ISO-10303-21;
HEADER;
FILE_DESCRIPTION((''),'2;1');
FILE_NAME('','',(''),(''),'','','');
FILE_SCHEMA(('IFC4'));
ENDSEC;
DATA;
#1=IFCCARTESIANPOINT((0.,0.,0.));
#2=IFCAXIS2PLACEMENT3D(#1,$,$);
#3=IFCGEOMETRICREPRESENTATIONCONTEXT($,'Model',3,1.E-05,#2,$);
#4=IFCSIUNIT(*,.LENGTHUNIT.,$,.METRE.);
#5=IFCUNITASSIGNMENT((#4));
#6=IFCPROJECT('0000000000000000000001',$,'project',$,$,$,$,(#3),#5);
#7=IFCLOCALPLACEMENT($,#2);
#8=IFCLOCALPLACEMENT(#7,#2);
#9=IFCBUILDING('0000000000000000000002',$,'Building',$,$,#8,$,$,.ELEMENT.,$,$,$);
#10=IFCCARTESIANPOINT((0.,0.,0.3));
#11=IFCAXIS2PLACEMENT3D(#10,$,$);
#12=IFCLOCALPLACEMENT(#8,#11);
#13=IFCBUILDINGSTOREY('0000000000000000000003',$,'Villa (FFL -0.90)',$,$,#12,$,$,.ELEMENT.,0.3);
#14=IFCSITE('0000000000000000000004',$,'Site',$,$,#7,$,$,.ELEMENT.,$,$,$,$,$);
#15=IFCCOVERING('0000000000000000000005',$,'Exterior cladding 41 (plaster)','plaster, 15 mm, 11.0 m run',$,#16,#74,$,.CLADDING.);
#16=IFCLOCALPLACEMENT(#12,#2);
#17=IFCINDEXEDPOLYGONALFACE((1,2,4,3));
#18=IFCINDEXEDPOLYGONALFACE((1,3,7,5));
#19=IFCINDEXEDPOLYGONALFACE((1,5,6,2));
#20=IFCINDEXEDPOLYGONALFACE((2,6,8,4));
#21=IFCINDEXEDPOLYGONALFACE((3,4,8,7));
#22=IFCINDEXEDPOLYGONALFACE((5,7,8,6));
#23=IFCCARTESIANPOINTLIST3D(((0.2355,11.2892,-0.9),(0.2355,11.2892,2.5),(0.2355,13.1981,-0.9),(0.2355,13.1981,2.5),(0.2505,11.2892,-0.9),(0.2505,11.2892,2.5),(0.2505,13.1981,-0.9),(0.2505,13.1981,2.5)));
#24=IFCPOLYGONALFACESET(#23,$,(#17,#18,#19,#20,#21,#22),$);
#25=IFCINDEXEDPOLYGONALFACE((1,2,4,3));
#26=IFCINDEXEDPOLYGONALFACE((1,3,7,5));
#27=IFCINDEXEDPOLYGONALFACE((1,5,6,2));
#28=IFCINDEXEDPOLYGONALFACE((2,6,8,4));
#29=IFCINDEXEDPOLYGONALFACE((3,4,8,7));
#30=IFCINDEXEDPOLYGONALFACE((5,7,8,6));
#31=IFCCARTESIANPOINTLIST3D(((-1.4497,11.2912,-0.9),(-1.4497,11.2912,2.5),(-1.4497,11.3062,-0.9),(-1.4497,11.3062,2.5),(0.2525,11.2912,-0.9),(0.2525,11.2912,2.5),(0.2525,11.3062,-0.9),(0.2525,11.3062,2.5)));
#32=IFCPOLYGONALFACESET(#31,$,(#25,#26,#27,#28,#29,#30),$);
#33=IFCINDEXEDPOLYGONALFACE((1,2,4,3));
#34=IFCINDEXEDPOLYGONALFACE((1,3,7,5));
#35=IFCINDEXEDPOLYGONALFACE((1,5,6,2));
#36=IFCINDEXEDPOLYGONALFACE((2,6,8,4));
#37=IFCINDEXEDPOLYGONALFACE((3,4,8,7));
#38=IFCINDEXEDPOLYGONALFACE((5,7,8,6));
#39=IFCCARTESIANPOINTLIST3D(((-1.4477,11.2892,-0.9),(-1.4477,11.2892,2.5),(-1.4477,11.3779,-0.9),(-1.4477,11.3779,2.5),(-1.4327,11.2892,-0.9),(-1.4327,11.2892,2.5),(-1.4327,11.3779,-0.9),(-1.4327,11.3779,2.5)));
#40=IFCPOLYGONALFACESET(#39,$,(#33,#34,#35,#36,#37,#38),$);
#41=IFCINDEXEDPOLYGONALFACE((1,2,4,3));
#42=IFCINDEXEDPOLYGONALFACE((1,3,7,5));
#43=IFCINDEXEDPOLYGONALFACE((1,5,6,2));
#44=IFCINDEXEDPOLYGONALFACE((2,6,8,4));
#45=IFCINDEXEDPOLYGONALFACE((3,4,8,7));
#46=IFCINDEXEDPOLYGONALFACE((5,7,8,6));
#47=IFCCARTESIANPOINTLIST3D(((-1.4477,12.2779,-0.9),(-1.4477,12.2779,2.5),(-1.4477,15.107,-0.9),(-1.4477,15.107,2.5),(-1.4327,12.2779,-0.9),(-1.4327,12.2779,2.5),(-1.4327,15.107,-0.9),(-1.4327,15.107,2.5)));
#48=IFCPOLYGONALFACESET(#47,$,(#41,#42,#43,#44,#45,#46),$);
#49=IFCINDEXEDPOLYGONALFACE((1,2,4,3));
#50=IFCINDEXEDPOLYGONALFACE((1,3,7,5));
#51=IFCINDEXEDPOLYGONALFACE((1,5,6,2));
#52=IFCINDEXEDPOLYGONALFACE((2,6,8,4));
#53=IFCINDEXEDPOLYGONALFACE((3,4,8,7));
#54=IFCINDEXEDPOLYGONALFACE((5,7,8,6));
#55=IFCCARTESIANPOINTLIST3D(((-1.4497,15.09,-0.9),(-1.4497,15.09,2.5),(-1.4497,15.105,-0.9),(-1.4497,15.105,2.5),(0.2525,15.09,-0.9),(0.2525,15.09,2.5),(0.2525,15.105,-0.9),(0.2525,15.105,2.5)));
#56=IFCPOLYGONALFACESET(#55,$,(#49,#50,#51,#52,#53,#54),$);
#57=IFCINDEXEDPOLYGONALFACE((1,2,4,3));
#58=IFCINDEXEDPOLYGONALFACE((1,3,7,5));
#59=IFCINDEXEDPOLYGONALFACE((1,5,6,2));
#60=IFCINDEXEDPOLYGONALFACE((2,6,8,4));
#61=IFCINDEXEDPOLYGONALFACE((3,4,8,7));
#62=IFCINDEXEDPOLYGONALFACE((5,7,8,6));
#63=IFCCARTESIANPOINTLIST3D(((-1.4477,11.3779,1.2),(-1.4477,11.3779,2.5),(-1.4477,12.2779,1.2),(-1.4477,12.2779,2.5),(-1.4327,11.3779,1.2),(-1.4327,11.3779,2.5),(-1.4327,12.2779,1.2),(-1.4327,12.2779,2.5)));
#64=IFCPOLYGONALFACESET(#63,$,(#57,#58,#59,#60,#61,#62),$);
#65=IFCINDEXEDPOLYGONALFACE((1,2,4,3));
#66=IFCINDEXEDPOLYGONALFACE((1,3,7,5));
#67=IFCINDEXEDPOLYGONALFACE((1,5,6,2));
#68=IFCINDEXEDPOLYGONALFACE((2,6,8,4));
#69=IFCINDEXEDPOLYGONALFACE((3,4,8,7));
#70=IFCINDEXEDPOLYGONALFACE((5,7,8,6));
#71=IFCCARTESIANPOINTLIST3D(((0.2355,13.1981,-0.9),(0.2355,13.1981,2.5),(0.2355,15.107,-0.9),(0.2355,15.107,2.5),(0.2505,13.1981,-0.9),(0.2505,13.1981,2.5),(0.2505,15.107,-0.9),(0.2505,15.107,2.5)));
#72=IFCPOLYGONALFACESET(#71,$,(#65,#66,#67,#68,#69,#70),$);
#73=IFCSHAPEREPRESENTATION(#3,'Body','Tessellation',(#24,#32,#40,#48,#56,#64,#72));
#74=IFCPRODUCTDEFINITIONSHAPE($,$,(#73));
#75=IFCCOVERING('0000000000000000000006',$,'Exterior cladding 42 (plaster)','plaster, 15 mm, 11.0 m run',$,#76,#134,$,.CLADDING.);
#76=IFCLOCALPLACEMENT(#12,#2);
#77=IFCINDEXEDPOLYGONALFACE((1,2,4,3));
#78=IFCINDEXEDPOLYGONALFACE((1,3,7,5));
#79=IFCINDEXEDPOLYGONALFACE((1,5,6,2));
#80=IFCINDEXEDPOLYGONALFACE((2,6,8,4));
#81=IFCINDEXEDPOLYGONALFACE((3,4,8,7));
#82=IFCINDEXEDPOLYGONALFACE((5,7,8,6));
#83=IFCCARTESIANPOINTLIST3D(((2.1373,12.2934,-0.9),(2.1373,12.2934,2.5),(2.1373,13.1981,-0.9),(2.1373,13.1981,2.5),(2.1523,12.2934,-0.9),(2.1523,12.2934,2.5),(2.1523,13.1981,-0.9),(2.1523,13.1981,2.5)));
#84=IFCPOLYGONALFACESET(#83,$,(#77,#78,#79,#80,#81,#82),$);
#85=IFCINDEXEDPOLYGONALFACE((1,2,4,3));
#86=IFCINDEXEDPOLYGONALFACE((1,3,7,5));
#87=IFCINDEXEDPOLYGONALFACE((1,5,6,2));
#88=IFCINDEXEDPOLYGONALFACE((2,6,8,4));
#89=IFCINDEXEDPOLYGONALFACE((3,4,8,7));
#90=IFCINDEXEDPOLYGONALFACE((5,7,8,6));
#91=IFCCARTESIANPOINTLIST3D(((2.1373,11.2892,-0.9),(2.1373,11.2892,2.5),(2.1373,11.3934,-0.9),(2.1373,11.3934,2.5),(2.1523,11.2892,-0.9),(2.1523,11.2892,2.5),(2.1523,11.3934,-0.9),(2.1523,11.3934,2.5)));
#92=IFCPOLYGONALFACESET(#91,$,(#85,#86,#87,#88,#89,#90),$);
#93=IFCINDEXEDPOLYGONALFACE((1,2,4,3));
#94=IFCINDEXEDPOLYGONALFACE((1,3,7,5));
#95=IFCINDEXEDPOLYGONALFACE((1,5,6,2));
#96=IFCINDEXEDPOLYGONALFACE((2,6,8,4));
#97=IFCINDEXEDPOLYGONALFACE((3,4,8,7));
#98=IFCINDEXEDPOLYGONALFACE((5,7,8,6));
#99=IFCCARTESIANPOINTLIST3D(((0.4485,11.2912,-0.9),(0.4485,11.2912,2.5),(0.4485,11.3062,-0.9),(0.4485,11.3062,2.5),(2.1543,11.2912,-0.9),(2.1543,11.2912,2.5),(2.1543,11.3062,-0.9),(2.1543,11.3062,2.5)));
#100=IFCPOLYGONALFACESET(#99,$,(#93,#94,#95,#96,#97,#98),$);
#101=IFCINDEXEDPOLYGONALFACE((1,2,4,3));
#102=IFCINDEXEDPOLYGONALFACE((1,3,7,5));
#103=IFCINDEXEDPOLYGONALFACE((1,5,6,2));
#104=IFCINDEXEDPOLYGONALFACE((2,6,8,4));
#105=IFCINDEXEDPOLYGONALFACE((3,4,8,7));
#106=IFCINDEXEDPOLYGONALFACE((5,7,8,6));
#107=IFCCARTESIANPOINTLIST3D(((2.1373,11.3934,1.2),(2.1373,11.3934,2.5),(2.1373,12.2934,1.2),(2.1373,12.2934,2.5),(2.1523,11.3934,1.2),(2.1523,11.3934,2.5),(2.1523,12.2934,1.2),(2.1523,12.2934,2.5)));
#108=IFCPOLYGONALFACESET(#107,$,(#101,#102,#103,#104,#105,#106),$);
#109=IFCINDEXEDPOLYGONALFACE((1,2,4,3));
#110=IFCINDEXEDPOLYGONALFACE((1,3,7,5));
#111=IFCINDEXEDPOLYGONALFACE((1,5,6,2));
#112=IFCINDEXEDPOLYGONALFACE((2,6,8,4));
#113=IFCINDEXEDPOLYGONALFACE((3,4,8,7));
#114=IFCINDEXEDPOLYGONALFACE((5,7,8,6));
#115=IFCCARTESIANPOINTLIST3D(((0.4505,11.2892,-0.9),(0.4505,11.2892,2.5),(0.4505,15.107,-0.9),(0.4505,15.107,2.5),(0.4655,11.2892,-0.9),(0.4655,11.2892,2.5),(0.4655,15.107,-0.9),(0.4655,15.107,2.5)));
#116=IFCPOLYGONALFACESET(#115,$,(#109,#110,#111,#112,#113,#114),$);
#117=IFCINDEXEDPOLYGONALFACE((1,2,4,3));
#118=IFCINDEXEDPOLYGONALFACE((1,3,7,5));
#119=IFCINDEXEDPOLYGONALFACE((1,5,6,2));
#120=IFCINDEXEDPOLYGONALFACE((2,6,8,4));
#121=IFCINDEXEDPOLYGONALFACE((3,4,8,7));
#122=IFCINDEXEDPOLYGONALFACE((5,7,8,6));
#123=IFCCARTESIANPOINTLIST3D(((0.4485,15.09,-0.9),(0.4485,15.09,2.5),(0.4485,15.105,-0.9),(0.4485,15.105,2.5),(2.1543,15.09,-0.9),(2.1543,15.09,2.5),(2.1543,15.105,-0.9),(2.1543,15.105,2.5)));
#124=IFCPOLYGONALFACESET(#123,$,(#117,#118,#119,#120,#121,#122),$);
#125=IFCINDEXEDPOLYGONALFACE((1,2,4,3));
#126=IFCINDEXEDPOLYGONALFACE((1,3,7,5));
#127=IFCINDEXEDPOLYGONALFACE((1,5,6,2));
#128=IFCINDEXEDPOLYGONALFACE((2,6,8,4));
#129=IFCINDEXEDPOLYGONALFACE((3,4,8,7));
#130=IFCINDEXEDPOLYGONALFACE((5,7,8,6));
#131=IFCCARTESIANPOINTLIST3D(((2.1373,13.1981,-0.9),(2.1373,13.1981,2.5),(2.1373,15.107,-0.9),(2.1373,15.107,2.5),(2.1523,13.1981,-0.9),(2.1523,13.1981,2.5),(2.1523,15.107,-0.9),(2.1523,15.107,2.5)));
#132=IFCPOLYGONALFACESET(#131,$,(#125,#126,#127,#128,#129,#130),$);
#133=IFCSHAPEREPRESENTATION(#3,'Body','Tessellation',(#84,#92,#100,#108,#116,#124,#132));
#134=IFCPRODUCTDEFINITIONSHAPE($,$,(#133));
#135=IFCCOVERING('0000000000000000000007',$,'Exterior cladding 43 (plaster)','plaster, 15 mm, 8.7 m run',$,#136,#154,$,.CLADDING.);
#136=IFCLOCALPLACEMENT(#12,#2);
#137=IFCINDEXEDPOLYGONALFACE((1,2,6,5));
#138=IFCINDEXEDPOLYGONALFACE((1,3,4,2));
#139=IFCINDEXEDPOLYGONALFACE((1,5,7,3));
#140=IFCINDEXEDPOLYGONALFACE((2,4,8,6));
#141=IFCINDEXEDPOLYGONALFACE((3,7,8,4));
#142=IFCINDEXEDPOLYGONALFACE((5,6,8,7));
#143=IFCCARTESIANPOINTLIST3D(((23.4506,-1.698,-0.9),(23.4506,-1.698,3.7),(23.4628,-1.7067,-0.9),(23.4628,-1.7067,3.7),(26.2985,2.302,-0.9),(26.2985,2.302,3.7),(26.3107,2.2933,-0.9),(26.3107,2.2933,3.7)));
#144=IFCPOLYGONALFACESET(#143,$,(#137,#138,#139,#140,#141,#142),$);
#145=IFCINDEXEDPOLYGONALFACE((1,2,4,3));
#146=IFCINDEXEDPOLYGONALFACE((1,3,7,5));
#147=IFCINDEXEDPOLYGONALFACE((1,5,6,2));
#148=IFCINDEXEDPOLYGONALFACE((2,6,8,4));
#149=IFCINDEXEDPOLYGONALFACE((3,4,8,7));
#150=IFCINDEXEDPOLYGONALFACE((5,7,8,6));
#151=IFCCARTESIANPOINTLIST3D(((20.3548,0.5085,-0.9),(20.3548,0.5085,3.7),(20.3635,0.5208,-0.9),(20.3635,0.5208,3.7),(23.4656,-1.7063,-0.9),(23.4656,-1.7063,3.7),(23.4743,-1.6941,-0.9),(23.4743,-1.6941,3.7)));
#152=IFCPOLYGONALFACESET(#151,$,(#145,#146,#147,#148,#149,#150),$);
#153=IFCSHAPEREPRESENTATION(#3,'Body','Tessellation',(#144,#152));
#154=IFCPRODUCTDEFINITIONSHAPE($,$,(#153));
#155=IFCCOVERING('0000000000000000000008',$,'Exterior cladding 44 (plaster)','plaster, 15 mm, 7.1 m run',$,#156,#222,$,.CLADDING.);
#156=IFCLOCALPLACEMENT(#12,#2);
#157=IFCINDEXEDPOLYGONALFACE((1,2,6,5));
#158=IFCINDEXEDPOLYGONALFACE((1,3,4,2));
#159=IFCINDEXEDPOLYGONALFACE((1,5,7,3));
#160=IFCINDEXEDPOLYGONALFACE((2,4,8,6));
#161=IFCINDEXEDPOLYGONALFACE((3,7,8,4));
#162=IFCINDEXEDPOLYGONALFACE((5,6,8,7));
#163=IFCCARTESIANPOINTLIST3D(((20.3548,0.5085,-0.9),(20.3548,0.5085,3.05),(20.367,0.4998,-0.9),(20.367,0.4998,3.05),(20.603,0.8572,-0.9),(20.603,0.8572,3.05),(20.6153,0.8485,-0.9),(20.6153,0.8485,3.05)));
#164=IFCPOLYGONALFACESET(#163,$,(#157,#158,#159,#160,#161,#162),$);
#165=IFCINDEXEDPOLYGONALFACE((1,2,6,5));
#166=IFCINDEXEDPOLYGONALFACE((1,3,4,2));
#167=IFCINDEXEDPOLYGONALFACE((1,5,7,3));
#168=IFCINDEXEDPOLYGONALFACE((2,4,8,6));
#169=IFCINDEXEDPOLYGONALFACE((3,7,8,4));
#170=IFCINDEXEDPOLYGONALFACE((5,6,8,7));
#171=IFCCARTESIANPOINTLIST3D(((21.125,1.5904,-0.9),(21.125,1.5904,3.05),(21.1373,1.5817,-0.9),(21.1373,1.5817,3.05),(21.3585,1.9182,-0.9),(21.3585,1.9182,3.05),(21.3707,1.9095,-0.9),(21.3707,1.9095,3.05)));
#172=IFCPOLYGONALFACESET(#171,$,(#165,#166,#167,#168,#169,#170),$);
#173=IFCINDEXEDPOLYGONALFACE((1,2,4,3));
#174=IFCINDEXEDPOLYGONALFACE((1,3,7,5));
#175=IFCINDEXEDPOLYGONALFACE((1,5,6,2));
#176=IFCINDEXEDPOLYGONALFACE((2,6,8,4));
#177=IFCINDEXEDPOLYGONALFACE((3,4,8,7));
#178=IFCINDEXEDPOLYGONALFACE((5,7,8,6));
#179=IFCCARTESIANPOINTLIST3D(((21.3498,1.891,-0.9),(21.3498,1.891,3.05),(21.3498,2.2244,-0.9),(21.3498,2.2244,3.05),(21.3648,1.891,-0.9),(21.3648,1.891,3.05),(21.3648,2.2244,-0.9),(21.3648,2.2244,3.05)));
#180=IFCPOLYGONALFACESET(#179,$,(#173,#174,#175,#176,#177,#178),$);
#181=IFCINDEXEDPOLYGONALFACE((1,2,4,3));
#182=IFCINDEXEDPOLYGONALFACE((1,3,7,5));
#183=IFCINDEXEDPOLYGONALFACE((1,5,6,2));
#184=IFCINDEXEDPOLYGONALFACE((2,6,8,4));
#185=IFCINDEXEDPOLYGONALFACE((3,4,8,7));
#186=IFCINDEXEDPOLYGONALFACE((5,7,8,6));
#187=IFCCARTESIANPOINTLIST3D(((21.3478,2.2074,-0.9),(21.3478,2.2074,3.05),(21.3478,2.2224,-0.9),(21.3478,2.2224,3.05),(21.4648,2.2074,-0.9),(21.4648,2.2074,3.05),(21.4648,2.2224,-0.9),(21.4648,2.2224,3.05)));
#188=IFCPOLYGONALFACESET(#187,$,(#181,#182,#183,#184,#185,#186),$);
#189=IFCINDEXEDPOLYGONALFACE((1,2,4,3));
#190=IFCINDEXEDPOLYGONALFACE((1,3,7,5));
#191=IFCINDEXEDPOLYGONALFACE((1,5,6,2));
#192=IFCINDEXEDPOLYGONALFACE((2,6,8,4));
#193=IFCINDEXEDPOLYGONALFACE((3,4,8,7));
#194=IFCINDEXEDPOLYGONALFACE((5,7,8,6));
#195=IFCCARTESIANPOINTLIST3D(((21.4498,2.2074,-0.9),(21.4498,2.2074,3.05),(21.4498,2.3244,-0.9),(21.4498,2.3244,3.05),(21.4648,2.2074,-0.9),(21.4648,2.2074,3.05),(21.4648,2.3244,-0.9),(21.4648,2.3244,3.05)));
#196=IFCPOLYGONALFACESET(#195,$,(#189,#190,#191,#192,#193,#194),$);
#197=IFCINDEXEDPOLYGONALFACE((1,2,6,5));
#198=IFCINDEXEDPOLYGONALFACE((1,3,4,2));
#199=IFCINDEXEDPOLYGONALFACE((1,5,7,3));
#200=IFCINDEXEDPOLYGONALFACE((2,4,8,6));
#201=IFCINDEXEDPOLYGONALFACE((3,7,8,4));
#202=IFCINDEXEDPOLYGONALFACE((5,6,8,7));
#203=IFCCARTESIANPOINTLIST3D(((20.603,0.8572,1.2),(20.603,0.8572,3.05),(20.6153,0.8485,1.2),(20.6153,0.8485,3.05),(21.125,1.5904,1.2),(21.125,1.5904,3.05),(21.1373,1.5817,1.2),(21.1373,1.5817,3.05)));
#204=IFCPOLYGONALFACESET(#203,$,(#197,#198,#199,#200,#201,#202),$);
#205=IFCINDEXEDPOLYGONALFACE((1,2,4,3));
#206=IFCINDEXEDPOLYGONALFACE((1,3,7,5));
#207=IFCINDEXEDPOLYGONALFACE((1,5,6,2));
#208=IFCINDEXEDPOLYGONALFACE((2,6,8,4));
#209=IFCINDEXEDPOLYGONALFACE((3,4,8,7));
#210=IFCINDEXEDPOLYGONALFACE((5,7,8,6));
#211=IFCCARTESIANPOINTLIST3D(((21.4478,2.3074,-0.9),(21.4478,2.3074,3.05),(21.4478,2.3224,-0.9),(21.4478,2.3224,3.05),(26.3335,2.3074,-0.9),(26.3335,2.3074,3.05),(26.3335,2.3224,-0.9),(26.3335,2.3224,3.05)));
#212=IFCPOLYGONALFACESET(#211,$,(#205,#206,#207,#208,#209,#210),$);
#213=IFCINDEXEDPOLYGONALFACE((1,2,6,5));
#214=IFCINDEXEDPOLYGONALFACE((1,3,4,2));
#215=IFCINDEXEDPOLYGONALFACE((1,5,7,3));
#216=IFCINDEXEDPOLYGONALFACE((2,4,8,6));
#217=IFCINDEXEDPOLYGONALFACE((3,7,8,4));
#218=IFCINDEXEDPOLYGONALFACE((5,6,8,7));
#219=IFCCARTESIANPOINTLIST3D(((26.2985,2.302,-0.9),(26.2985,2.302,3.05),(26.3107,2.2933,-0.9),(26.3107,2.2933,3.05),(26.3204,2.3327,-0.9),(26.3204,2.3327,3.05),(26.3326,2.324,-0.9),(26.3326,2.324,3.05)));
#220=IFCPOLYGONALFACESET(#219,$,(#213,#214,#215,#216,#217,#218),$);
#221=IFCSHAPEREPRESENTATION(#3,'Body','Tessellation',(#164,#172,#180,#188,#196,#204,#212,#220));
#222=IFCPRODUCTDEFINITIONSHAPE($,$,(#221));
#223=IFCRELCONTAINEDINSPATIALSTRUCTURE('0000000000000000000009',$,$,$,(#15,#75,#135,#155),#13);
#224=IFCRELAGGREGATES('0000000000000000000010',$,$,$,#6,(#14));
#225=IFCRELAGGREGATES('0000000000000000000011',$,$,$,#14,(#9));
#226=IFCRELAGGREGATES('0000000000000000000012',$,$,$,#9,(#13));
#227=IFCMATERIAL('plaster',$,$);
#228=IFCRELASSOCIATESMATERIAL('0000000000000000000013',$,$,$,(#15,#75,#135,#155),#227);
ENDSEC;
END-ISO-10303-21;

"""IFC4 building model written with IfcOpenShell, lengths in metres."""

from ifc_helpers import new_model, si_unit, frame, origin, origin_with_axes, place, context, project, spatial, polyline, outline, extrude, material, element, save


model = new_model("IFC4")

# Units and contexts
model_context = context("Model", 3, precision=1e-05, world=origin())
ifc_project = project(units=[si_unit("LENGTHUNIT", "METRE")], contexts=[model_context])

# Site, building, storey
site_placement = place(None, origin())
site = spatial("IfcSite", under=ifc_project, at=site_placement, Name="Site", CompositionType="ELEMENT")
building_placement = place(site_placement, origin())
building = spatial("IfcBuilding", under=site, at=building_placement, Name="Building", CompositionType="ELEMENT")
storey_placement = place(building_placement, frame((0.0, 0.0, 0.3)))
storey = spatial("IfcBuildingStorey", under=building, at=storey_placement, Name="Villa (FFL -0.90)", CompositionType="ELEMENT", Elevation=0.3)

# Coverings
ifc_material = material(Name="plaster")
covering_1_placement = place(storey_placement, origin_with_axes())
element("IfcCovering", 1, at=covering_1_placement, inside=storey, material=ifc_material, Name="Exterior cladding 41 (plaster)", Description="plaster, 15 mm, 11.0 m run", PredefinedType="CLADDING", context=model_context, shape_type="SweptSolid", body=[
    extrude(outline(polyline([(0.2355, 13.1981), (0.2355, 11.2892), (0.2505, 11.2892), (0.2505, 13.1981), (0.2355, 13.1981)])), frame((0.0, 0.0, -0.9)), (0.0, 0.0, 1.0), 3.4),
    extrude(outline(polyline([(0.2525, 11.3062), (-1.4497, 11.3062), (-1.4497, 11.2912), (0.2525, 11.2912), (0.2525, 11.3062)])), frame((0.0, 0.0, -0.9)), (0.0, 0.0, 1.0), 3.4),
    extrude(outline(polyline([(-1.4327, 11.2892), (-1.4327, 11.3779), (-1.4477, 11.3779), (-1.4477, 11.2892), (-1.4327, 11.2892)])), frame((0.0, 0.0, -0.9)), (0.0, 0.0, 1.0), 3.4),
    extrude(outline(polyline([(-1.4327, 12.2779), (-1.4327, 15.107), (-1.4477, 15.107), (-1.4477, 12.2779), (-1.4327, 12.2779)])), frame((0.0, 0.0, -0.9)), (0.0, 0.0, 1.0), 3.4),
    extrude(outline(polyline([(-1.4497, 15.09), (0.2525, 15.09), (0.2525, 15.105), (-1.4497, 15.105), (-1.4497, 15.09)])), frame((0.0, 0.0, -0.9)), (0.0, 0.0, 1.0), 3.4),
    extrude(outline(polyline([(-1.4327, 11.3779), (-1.4327, 12.2779), (-1.4477, 12.2779), (-1.4477, 11.3779), (-1.4327, 11.3779)])), frame((0.0, 0.0, 1.2)), (0.0, 0.0, 1.0), 1.3),
    extrude(outline(polyline([(0.2355, 15.107), (0.2355, 13.1981), (0.2505, 13.1981), (0.2505, 15.107), (0.2355, 15.107)])), frame((0.0, 0.0, -0.9)), (0.0, 0.0, 1.0), 3.4),
])
covering_2_placement = place(storey_placement, origin_with_axes())
element("IfcCovering", 2, at=covering_2_placement, inside=storey, material=ifc_material, Name="Exterior cladding 42 (plaster)", Description="plaster, 15 mm, 11.0 m run", PredefinedType="CLADDING", context=model_context, shape_type="SweptSolid", body=[
    extrude(outline(polyline([(2.1373, 13.1981), (2.1373, 12.2934), (2.1523, 12.2934), (2.1523, 13.1981), (2.1373, 13.1981)])), frame((0.0, 0.0, -0.9)), (0.0, 0.0, 1.0), 3.4),
    extrude(outline(polyline([(2.1373, 11.3934), (2.1373, 11.2892), (2.1523, 11.2892), (2.1523, 11.3934), (2.1373, 11.3934)])), frame((0.0, 0.0, -0.9)), (0.0, 0.0, 1.0), 3.4),
    extrude(outline(polyline([(2.1543, 11.3062), (0.4485, 11.3062), (0.4485, 11.2912), (2.1543, 11.2912), (2.1543, 11.3062)])), frame((0.0, 0.0, -0.9)), (0.0, 0.0, 1.0), 3.4),
    extrude(outline(polyline([(2.1373, 12.2934), (2.1373, 11.3934), (2.1523, 11.3934), (2.1523, 12.2934), (2.1373, 12.2934)])), frame((0.0, 0.0, 1.2)), (0.0, 0.0, 1.0), 1.3),
    extrude(outline(polyline([(0.4655, 11.2892), (0.4655, 15.107), (0.4505, 15.107), (0.4505, 11.2892), (0.4655, 11.2892)])), frame((0.0, 0.0, -0.9)), (0.0, 0.0, 1.0), 3.4),
    extrude(outline(polyline([(0.4485, 15.09), (2.1543, 15.09), (2.1543, 15.105), (0.4485, 15.105), (0.4485, 15.09)])), frame((0.0, 0.0, -0.9)), (0.0, 0.0, 1.0), 3.4),
    extrude(outline(polyline([(2.1373, 15.107), (2.1373, 13.1981), (2.1523, 13.1981), (2.1523, 15.107), (2.1373, 15.107)])), frame((0.0, 0.0, -0.9)), (0.0, 0.0, 1.0), 3.4),
])
covering_3_placement = place(storey_placement, origin_with_axes())
element("IfcCovering", 3, at=covering_3_placement, inside=storey, material=ifc_material, Name="Exterior cladding 43 (plaster)", Description="plaster, 15 mm, 8.7 m run", PredefinedType="CLADDING", context=model_context, shape_type="SweptSolid", body=[
    extrude(outline(polyline([(26.2985, 2.302), (23.4506, -1.698), (23.4628, -1.7067), (26.3107, 2.2933), (26.2985, 2.302)])), frame((0.0, 0.0, -0.9)), (0.0, 0.0, 1.0), 4.6),
    extrude(outline(polyline([(23.4743, -1.6941), (20.3635, 0.5208), (20.3548, 0.5085), (23.4656, -1.7063), (23.4743, -1.6941)])), frame((0.0, 0.0, -0.9)), (0.0, 0.0, 1.0), 4.6),
])
covering_4_placement = place(storey_placement, origin_with_axes())
element("IfcCovering", 4, at=covering_4_placement, inside=storey, material=ifc_material, Name="Exterior cladding 44 (plaster)", Description="plaster, 15 mm, 7.1 m run", PredefinedType="CLADDING", context=model_context, shape_type="SweptSolid", body=[
    extrude(outline(polyline([(20.367, 0.4998), (20.6153, 0.8485), (20.603, 0.8572), (20.3548, 0.5085), (20.367, 0.4998)])), frame((0.0, 0.0, -0.9)), (0.0, 0.0, 1.0), 3.95),
    extrude(outline(polyline([(21.1373, 1.5817), (21.3707, 1.9095), (21.3585, 1.9182), (21.125, 1.5904), (21.1373, 1.5817)])), frame((0.0, 0.0, -0.9)), (0.0, 0.0, 1.0), 3.95),
    extrude(outline(polyline([(21.3648, 1.891), (21.3648, 2.2244), (21.3498, 2.2244), (21.3498, 1.891), (21.3648, 1.891)])), frame((0.0, 0.0, -0.9)), (0.0, 0.0, 1.0), 3.95),
    extrude(outline(polyline([(21.3478, 2.2074), (21.4648, 2.2074), (21.4648, 2.2224), (21.3478, 2.2224), (21.3478, 2.2074)])), frame((0.0, 0.0, -0.9)), (0.0, 0.0, 1.0), 3.95),
    extrude(outline(polyline([(21.4648, 2.2074), (21.4648, 2.3244), (21.4498, 2.3244), (21.4498, 2.2074), (21.4648, 2.2074)])), frame((0.0, 0.0, -0.9)), (0.0, 0.0, 1.0), 3.95),
    extrude(outline(polyline([(20.6153, 0.8485), (21.1373, 1.5817), (21.125, 1.5904), (20.603, 0.8572), (20.6153, 0.8485)])), frame((0.0, 0.0, 1.2)), (0.0, 0.0, 1.0), 1.85),
    extrude(outline(polyline([(21.4478, 2.3074), (26.3335, 2.3074), (26.3335, 2.3224), (21.4478, 2.3224), (21.4478, 2.3074)])), frame((0.0, 0.0, -0.9)), (0.0, 0.0, 1.0), 3.95),
    extrude(outline(polyline([(26.3204, 2.3327), (26.2985, 2.302), (26.3107, 2.2933), (26.3326, 2.324), (26.3204, 2.3327)])), frame((0.0, 0.0, -0.9)), (0.0, 0.0, 1.0), 3.95),
])

save(model, "model.ifc")
